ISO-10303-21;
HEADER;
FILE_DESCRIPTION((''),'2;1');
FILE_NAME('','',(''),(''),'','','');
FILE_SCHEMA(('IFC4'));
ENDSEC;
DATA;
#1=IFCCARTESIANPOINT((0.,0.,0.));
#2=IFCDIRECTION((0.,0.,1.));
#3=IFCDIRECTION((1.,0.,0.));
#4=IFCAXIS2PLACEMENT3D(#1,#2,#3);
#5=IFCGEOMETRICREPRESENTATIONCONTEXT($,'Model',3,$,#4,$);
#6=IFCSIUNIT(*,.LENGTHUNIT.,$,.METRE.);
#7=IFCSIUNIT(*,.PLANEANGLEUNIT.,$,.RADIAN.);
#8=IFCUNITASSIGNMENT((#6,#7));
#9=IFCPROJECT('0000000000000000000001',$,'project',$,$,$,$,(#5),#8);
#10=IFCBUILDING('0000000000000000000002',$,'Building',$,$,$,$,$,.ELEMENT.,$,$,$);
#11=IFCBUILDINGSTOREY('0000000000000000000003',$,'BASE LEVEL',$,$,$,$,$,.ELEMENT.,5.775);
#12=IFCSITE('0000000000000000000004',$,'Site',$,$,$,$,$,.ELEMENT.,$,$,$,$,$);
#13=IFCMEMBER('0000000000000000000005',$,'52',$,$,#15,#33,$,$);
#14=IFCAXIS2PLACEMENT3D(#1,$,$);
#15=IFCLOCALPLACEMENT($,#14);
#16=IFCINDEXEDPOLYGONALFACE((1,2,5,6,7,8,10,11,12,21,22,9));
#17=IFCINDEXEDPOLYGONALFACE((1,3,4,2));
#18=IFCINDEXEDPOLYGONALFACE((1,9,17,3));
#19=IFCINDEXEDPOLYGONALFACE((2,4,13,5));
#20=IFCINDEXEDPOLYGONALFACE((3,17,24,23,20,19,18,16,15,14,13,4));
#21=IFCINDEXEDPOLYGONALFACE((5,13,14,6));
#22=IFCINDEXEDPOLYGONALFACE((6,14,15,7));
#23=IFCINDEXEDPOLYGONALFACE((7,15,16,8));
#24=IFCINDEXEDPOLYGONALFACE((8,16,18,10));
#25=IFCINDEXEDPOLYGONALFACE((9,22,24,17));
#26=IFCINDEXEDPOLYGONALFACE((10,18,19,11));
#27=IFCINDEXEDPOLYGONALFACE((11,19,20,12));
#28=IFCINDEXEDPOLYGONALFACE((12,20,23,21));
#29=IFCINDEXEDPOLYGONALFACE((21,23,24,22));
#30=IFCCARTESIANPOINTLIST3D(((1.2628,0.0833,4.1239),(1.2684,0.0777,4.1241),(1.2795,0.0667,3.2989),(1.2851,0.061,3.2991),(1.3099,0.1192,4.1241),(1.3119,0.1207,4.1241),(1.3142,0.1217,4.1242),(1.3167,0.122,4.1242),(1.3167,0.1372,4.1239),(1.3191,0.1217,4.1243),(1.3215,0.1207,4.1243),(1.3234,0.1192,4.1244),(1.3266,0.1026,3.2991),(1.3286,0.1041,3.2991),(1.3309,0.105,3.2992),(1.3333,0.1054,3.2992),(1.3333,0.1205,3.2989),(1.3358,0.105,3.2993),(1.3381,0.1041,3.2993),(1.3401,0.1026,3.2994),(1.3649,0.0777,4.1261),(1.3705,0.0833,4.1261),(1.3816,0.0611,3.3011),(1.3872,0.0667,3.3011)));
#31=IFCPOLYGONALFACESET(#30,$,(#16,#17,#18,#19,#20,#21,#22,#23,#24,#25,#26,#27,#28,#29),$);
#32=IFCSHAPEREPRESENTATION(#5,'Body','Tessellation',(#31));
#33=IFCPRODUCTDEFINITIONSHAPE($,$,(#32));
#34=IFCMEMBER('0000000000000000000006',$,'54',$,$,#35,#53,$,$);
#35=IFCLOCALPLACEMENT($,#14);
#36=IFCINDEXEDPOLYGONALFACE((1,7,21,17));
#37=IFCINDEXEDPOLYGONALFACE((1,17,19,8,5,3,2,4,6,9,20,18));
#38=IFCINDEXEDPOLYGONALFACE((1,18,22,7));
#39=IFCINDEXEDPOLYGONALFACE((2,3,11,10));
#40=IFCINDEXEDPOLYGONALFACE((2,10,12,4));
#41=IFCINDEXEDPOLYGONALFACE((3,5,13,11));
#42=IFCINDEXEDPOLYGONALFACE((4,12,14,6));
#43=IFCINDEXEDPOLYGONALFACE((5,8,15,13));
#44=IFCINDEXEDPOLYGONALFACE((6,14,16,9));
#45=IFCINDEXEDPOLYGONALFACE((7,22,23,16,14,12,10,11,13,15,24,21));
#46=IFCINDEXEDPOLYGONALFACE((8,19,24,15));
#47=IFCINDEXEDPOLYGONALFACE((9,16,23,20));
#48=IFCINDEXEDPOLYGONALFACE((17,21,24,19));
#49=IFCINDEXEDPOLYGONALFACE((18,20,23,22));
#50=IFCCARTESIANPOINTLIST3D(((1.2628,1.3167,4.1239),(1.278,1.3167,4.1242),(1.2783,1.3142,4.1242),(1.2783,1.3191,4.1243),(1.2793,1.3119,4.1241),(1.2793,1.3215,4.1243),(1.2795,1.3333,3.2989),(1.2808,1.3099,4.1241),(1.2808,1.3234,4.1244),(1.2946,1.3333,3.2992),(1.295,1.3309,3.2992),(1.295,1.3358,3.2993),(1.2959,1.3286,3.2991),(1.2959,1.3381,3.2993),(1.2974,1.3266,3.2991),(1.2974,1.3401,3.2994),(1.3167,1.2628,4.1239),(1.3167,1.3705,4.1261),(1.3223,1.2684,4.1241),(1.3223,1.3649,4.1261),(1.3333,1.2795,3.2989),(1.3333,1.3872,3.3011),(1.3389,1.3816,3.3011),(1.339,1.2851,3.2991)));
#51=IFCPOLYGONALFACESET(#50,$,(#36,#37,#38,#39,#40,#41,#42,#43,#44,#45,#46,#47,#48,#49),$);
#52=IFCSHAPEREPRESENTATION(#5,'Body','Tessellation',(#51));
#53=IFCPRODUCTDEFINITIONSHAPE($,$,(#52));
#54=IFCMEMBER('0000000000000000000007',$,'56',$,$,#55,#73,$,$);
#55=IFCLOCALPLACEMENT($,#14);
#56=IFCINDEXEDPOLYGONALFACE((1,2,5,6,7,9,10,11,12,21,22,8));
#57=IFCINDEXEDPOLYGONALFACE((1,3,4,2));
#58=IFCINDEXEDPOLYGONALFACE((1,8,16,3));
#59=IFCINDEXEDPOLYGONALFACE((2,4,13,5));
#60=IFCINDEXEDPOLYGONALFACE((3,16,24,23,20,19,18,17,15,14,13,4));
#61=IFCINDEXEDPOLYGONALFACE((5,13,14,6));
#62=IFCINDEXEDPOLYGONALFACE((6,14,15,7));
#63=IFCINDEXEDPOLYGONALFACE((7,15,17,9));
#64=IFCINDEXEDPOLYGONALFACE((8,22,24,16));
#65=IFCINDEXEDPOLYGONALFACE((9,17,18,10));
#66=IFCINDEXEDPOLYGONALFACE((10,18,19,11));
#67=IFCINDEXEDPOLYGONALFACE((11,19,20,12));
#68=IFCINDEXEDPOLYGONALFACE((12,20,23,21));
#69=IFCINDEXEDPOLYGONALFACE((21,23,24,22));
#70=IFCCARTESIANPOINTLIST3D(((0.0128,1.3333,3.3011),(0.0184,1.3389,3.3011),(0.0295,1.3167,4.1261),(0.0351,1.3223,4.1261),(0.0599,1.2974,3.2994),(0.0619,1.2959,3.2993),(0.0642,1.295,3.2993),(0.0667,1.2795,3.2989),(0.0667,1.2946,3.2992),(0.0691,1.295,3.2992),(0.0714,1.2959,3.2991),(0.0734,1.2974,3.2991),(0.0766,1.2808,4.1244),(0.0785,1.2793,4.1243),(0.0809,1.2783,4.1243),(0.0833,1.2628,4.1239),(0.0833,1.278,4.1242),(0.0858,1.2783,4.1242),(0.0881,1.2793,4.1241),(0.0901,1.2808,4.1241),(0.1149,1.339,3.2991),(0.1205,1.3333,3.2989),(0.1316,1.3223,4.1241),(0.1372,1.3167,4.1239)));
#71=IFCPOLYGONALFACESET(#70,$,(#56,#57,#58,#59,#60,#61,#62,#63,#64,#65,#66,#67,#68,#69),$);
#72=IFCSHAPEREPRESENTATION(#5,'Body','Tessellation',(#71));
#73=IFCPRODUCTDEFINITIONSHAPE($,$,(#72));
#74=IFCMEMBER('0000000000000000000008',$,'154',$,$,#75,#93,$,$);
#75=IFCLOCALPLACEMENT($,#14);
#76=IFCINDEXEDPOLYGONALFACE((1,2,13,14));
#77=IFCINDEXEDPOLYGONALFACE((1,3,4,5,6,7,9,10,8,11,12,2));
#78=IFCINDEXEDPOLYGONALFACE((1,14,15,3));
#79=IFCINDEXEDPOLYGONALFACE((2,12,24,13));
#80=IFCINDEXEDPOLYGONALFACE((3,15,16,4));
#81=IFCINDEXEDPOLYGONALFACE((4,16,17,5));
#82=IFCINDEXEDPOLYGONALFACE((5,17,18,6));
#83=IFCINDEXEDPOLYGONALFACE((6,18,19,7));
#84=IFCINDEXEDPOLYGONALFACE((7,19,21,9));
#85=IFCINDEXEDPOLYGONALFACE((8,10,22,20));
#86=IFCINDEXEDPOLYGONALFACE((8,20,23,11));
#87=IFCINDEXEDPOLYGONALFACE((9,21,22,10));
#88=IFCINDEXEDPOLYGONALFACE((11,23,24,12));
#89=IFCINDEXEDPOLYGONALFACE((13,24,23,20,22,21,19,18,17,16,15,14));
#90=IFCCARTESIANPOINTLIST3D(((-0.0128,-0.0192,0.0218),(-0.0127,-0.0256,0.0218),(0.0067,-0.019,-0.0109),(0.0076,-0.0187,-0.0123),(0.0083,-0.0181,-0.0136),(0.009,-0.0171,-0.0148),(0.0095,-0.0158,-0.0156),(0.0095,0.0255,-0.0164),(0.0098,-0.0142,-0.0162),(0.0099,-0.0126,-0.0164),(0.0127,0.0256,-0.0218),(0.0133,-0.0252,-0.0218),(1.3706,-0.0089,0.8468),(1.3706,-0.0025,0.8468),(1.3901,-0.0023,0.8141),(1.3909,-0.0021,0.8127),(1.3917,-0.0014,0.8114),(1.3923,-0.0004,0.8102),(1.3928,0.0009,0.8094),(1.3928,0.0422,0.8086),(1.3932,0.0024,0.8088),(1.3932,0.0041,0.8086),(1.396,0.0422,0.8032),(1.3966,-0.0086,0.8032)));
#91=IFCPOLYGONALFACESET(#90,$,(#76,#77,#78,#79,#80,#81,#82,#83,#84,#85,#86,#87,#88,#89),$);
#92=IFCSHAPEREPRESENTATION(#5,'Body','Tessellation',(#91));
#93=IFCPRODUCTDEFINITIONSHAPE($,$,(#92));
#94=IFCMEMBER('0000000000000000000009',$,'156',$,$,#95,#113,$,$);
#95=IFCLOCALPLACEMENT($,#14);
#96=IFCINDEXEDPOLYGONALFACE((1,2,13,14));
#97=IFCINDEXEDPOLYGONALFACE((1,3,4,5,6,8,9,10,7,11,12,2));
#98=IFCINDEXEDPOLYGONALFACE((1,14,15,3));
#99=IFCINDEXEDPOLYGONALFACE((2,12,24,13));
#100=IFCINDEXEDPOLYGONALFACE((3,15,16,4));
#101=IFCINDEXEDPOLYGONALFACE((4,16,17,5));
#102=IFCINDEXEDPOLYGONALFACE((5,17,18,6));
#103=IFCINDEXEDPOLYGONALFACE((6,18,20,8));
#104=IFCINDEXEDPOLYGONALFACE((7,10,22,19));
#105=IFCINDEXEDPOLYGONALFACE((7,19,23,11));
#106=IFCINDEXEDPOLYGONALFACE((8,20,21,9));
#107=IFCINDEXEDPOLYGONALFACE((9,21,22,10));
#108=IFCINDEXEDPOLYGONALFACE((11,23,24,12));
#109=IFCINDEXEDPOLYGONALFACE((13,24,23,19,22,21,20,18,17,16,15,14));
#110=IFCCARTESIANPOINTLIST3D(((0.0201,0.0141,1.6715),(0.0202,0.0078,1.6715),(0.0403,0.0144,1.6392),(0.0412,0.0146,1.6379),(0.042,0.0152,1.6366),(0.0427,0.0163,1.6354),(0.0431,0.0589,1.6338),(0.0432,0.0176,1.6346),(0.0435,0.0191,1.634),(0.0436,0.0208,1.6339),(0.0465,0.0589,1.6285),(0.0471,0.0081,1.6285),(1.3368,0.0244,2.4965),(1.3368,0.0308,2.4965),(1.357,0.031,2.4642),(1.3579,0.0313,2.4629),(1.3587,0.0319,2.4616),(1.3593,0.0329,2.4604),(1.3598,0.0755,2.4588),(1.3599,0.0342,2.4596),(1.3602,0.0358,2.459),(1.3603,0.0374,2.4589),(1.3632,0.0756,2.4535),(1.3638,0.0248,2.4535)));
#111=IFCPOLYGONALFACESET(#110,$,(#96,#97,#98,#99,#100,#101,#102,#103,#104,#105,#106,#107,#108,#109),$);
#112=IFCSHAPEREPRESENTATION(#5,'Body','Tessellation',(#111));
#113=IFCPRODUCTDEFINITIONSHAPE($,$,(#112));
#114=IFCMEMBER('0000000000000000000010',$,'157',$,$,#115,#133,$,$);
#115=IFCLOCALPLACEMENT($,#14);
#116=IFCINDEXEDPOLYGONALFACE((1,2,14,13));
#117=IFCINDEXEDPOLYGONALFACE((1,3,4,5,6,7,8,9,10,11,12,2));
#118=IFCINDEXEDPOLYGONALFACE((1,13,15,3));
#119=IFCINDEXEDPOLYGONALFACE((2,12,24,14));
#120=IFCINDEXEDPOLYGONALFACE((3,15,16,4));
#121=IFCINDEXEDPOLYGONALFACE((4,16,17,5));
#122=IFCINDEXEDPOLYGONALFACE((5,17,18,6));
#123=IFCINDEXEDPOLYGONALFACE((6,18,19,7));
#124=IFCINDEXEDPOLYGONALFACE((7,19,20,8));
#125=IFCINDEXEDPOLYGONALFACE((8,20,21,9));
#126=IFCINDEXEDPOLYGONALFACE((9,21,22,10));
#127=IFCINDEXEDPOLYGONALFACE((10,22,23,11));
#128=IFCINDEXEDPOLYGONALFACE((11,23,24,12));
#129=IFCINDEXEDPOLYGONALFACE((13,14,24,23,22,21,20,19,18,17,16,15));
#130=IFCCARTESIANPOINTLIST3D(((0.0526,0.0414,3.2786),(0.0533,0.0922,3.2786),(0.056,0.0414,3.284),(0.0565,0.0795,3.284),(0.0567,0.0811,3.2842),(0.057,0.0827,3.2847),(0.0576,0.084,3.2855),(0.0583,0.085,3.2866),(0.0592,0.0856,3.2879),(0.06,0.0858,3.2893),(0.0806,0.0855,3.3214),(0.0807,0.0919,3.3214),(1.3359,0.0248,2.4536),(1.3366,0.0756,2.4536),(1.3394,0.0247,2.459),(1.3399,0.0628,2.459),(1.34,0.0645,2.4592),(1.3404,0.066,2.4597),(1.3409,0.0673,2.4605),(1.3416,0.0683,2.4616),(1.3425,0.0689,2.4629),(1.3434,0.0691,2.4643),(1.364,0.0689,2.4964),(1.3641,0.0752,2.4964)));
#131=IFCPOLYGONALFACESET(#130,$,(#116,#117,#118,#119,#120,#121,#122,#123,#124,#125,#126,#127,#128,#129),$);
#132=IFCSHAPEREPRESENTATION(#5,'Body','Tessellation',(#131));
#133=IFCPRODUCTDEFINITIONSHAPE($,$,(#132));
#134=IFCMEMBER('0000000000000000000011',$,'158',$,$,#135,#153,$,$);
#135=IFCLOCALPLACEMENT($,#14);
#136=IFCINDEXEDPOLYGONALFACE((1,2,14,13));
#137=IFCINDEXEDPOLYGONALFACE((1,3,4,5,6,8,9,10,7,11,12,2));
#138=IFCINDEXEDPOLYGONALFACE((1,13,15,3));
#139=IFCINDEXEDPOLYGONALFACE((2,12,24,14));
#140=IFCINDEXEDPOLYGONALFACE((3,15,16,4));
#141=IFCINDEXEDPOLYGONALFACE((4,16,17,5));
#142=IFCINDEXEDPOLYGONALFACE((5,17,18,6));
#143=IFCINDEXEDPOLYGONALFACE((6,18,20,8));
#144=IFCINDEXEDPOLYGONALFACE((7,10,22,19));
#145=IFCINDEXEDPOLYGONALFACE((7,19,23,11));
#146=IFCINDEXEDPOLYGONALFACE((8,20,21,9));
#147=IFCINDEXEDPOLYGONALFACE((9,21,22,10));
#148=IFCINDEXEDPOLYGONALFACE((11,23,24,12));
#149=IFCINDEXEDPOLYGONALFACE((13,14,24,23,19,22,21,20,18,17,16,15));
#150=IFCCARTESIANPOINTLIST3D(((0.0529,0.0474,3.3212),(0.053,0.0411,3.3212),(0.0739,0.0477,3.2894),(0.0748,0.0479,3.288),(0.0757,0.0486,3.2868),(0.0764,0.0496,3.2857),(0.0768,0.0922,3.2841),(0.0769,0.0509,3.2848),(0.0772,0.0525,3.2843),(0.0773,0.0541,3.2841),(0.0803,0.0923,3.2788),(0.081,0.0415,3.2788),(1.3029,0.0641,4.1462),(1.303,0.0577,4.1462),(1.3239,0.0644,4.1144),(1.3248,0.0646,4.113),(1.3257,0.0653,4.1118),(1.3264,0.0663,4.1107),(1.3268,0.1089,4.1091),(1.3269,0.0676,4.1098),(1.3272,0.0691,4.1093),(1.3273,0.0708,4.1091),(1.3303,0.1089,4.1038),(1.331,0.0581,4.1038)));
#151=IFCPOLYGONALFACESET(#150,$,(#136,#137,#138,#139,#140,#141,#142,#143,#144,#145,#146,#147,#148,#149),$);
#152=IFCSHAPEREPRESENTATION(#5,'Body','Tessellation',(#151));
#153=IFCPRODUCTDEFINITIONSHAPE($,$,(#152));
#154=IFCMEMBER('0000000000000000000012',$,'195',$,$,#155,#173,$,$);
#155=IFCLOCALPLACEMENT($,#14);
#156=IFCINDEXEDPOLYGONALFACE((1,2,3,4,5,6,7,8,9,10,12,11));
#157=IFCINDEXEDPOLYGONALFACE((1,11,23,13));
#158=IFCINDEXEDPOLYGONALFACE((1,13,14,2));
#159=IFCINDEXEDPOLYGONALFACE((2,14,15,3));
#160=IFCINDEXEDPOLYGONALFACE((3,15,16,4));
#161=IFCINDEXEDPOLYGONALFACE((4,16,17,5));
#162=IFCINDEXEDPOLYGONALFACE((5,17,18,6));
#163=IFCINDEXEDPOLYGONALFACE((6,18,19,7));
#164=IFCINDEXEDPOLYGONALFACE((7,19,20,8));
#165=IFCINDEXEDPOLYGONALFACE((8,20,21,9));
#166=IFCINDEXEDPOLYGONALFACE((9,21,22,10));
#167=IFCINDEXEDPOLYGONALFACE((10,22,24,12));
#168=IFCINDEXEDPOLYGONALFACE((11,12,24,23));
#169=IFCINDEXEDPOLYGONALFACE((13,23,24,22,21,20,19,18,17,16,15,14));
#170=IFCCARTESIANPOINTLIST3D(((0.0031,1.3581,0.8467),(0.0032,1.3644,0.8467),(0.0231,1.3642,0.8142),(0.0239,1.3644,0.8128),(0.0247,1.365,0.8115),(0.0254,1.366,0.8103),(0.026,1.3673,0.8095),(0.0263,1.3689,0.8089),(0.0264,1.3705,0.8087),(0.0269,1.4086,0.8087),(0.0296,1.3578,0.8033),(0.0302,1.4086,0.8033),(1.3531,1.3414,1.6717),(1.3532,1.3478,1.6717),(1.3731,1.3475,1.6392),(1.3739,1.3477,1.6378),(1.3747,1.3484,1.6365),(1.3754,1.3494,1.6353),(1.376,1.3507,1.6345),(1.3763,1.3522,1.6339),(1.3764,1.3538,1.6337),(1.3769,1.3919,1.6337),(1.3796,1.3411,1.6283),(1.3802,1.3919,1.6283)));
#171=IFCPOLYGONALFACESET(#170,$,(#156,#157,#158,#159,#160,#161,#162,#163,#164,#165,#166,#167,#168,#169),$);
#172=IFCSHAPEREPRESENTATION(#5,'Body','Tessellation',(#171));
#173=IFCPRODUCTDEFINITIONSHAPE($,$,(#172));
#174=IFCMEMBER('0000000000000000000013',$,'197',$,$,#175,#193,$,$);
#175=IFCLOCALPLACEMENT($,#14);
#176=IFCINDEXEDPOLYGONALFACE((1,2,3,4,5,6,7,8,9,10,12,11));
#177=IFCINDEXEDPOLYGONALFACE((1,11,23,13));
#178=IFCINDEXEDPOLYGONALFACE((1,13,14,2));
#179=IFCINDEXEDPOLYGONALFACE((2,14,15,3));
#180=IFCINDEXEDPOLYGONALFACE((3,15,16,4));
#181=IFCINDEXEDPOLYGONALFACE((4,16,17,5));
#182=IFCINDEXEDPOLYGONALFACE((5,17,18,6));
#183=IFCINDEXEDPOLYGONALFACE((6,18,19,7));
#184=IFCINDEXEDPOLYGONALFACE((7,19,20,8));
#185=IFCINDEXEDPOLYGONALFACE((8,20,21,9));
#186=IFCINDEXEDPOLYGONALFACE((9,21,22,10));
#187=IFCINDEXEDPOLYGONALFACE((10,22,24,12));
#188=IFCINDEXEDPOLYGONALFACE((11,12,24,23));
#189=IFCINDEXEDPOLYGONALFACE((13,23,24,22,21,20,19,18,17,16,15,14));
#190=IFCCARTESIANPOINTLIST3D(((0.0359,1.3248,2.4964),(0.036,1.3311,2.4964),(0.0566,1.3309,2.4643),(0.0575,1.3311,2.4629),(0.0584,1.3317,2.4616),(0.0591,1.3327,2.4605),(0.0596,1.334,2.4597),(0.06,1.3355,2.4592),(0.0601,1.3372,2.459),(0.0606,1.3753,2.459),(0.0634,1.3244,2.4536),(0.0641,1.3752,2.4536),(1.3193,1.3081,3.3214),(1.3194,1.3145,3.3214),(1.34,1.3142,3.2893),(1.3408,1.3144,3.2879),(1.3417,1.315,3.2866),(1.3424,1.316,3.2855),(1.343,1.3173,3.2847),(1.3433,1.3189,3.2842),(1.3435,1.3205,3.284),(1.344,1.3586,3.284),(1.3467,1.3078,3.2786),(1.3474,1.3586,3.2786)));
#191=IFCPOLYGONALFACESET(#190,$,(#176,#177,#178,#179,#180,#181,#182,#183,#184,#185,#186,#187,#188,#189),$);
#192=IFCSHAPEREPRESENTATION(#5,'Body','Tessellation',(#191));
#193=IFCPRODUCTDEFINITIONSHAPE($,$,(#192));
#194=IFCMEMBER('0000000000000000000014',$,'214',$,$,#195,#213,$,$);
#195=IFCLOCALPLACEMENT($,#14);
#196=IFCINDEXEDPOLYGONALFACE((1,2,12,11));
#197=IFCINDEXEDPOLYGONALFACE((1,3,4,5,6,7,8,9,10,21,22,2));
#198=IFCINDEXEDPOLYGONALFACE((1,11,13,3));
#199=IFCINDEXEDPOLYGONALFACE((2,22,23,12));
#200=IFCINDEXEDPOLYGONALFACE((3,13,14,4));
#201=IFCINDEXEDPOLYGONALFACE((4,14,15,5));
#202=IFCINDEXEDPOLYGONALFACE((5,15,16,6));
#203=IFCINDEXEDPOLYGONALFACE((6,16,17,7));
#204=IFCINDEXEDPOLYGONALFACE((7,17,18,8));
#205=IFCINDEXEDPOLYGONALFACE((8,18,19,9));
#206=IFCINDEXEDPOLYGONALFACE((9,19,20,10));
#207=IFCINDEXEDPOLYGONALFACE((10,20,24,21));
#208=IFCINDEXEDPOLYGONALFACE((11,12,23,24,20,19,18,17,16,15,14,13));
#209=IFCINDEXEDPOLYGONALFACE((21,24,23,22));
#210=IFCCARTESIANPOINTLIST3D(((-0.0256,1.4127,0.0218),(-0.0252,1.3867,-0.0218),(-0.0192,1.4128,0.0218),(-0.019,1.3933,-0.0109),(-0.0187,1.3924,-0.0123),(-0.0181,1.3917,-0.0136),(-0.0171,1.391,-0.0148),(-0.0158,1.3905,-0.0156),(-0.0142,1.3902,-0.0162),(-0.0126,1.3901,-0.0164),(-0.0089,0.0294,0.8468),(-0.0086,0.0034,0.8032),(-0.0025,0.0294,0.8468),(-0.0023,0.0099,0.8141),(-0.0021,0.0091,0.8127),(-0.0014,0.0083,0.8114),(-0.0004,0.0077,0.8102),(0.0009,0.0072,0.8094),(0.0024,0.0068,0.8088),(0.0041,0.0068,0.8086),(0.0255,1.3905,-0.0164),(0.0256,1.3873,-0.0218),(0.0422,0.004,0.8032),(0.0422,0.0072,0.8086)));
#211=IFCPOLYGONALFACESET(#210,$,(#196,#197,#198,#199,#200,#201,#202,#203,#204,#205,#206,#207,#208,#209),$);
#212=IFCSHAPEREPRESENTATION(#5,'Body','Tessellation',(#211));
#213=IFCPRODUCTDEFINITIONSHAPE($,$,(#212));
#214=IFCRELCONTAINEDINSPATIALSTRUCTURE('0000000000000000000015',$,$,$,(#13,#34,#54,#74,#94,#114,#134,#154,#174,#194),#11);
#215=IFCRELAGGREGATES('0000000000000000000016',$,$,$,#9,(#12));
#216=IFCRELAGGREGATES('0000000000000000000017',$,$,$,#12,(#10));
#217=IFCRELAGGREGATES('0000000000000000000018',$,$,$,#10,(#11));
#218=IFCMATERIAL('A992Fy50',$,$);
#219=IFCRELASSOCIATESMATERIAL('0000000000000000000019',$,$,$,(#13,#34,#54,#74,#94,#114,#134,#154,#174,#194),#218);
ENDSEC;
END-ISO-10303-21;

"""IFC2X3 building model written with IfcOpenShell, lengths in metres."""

from ifc_helpers import new_model, si_unit, frame, origin_with_axes, origin_2d_with_axis, place, context, project, spatial, l_section, extrude, material, element, save


model = new_model("IFC2X3")

# Units and contexts
model_context = context("Model", 3, world=origin_with_axes())
ifc_project = project(units=[si_unit("LENGTHUNIT", "METRE"), si_unit("PLANEANGLEUNIT", "RADIAN")], contexts=[model_context])

# Site, building, storey
site = spatial("IfcSite", under=ifc_project, Name="Site", CompositionType="ELEMENT")
building = spatial("IfcBuilding", under=site, Name="Building", CompositionType="ELEMENT")
storey = spatial("IfcBuildingStorey", under=building, Name="BASE LEVEL", CompositionType="ELEMENT", Elevation=5.775)

# Members
ifc_material = material(Name="A992Fy50")
for number, where, z_axis, x_axis, name in (
    (1, (1.3333, 0.0667, 3.3), (-0.020194, 0.020194, 0.999592), (-0.707107, -0.707107, 0.0), "52"),
    (2, (1.3333, 1.3333, 3.3), (-0.020194, -0.020194, 0.999592), (0.707107, -0.707107, 0.0), "54"),
    (3, (0.0667, 1.3333, 3.3), (0.020194, -0.020194, 0.999592), (0.707107, 0.707107, 0.0), "56"),
):
    element("IfcMember", number, at=place(None, frame(where, z_axis=z_axis, x_axis=x_axis)), inside=storey, material=ifc_material, Name=name, context=model_context, shape_type="SweptSolid", body=[
        extrude(l_section(Depth=0.0762, Width=0.0762, Thickness=0.0079, FilletRadius=0.0096, at=origin_2d_with_axis()), origin_with_axes(), (0.0, 0.0, 1.0), 0.8253),
    ])
member_1_placement = place(None, frame((0.0, 0.0, 0.0), z_axis=(0.858813, 0.010347, 0.512184), x_axis=(-0.012047, 0.999927, 0.0)))
element("IfcMember", 4, at=member_1_placement, inside=storey, material=ifc_material, Name="154", context=model_context, shape_type="SweptSolid", body=[
    extrude(l_section(Depth=0.0508, Width=0.0508, Thickness=0.0063, FilletRadius=0.0063, at=origin_2d_with_axis()), origin_with_axes(), (0.0, 0.0, 1.0), 1.6107),
])
member_2_placement = place(None, frame((0.0333, 0.0333, 1.65), z_axis=(0.847346, 0.010726, 0.530932), x_axis=(-0.012047, 0.999927, 0.0)))
element("IfcMember", 5, at=member_2_placement, inside=storey, material=ifc_material, Name="156", context=model_context, shape_type="SweptSolid", body=[
    extrude(l_section(Depth=0.0508, Width=0.0508, Thickness=0.0063, FilletRadius=0.0063, at=origin_2d_with_axis()), origin_with_axes(), (0.0, 0.0, 1.0), 1.5539),
])
member_3_placement = place(None, frame((1.35, 0.05, 2.475), z_axis=(-0.841128, 0.010924, 0.540725), x_axis=(-0.012345, -0.999924, 0.0)))
element("IfcMember", 6, at=member_3_placement, inside=storey, material=ifc_material, Name="157", context=model_context, shape_type="SweptSolid", body=[
    extrude(l_section(Depth=0.0508, Width=0.0508, Thickness=0.0063, FilletRadius=0.0063, at=origin_2d_with_axis()), origin_with_axes(), (0.0, 0.0, 1.0), 1.5257),
])
member_4_placement = place(None, frame((0.0667, 0.0667, 3.3), z_axis=(0.834558, 0.011127, 0.550808), x_axis=(-0.013332, 0.999911, 0.0)))
element("IfcMember", 7, at=member_4_placement, inside=storey, material=ifc_material, Name="158", context=model_context, shape_type="SweptSolid", body=[
    extrude(l_section(Depth=0.0508, Width=0.0508, Thickness=0.0063, FilletRadius=0.0063, at=origin_2d_with_axis()), origin_with_axes(), (0.0, 0.0, 1.0), 1.4978),
])
member_5_placement = place(None, frame((0.0167, 1.3833, 0.825), z_axis=(0.853234, -0.010534, 0.521421), x_axis=(0.012345, 0.999924, 0.0)))
element("IfcMember", 8, at=member_5_placement, inside=storey, material=ifc_material, Name="195", context=model_context, shape_type="SweptSolid", body=[
    extrude(l_section(Depth=0.0508, Width=0.0508, Thickness=0.0063, FilletRadius=0.0063, at=origin_2d_with_axis()), origin_with_axes(), (0.0, 0.0, 1.0), 1.5822),
])
member_6_placement = place(None, frame((0.05, 1.35, 2.475), z_axis=(0.841128, -0.010924, 0.540725), x_axis=(0.012345, 0.999924, 0.0)))
element("IfcMember", 9, at=member_6_placement, inside=storey, material=ifc_material, Name="197", context=model_context, shape_type="SweptSolid", body=[
    extrude(l_section(Depth=0.0508, Width=0.0508, Thickness=0.0063, FilletRadius=0.0063, at=origin_2d_with_axis()), origin_with_axes(), (0.0, 0.0, 1.0), 1.5257),
])
member_7_placement = place(None, frame((0.0, 1.4, 0.0), z_axis=(0.010347, -0.858813, 0.512184), x_axis=(0.999927, 0.012047, 0.0)))
element("IfcMember", 10, at=member_7_placement, inside=storey, material=ifc_material, Name="214", context=model_context, shape_type="SweptSolid", body=[
    extrude(l_section(Depth=0.0508, Width=0.0508, Thickness=0.0063, FilletRadius=0.0063, at=origin_2d_with_axis()), origin_with_axes(), (0.0, 0.0, 1.0), 1.6107),
])

save(model, "model.ifc")
